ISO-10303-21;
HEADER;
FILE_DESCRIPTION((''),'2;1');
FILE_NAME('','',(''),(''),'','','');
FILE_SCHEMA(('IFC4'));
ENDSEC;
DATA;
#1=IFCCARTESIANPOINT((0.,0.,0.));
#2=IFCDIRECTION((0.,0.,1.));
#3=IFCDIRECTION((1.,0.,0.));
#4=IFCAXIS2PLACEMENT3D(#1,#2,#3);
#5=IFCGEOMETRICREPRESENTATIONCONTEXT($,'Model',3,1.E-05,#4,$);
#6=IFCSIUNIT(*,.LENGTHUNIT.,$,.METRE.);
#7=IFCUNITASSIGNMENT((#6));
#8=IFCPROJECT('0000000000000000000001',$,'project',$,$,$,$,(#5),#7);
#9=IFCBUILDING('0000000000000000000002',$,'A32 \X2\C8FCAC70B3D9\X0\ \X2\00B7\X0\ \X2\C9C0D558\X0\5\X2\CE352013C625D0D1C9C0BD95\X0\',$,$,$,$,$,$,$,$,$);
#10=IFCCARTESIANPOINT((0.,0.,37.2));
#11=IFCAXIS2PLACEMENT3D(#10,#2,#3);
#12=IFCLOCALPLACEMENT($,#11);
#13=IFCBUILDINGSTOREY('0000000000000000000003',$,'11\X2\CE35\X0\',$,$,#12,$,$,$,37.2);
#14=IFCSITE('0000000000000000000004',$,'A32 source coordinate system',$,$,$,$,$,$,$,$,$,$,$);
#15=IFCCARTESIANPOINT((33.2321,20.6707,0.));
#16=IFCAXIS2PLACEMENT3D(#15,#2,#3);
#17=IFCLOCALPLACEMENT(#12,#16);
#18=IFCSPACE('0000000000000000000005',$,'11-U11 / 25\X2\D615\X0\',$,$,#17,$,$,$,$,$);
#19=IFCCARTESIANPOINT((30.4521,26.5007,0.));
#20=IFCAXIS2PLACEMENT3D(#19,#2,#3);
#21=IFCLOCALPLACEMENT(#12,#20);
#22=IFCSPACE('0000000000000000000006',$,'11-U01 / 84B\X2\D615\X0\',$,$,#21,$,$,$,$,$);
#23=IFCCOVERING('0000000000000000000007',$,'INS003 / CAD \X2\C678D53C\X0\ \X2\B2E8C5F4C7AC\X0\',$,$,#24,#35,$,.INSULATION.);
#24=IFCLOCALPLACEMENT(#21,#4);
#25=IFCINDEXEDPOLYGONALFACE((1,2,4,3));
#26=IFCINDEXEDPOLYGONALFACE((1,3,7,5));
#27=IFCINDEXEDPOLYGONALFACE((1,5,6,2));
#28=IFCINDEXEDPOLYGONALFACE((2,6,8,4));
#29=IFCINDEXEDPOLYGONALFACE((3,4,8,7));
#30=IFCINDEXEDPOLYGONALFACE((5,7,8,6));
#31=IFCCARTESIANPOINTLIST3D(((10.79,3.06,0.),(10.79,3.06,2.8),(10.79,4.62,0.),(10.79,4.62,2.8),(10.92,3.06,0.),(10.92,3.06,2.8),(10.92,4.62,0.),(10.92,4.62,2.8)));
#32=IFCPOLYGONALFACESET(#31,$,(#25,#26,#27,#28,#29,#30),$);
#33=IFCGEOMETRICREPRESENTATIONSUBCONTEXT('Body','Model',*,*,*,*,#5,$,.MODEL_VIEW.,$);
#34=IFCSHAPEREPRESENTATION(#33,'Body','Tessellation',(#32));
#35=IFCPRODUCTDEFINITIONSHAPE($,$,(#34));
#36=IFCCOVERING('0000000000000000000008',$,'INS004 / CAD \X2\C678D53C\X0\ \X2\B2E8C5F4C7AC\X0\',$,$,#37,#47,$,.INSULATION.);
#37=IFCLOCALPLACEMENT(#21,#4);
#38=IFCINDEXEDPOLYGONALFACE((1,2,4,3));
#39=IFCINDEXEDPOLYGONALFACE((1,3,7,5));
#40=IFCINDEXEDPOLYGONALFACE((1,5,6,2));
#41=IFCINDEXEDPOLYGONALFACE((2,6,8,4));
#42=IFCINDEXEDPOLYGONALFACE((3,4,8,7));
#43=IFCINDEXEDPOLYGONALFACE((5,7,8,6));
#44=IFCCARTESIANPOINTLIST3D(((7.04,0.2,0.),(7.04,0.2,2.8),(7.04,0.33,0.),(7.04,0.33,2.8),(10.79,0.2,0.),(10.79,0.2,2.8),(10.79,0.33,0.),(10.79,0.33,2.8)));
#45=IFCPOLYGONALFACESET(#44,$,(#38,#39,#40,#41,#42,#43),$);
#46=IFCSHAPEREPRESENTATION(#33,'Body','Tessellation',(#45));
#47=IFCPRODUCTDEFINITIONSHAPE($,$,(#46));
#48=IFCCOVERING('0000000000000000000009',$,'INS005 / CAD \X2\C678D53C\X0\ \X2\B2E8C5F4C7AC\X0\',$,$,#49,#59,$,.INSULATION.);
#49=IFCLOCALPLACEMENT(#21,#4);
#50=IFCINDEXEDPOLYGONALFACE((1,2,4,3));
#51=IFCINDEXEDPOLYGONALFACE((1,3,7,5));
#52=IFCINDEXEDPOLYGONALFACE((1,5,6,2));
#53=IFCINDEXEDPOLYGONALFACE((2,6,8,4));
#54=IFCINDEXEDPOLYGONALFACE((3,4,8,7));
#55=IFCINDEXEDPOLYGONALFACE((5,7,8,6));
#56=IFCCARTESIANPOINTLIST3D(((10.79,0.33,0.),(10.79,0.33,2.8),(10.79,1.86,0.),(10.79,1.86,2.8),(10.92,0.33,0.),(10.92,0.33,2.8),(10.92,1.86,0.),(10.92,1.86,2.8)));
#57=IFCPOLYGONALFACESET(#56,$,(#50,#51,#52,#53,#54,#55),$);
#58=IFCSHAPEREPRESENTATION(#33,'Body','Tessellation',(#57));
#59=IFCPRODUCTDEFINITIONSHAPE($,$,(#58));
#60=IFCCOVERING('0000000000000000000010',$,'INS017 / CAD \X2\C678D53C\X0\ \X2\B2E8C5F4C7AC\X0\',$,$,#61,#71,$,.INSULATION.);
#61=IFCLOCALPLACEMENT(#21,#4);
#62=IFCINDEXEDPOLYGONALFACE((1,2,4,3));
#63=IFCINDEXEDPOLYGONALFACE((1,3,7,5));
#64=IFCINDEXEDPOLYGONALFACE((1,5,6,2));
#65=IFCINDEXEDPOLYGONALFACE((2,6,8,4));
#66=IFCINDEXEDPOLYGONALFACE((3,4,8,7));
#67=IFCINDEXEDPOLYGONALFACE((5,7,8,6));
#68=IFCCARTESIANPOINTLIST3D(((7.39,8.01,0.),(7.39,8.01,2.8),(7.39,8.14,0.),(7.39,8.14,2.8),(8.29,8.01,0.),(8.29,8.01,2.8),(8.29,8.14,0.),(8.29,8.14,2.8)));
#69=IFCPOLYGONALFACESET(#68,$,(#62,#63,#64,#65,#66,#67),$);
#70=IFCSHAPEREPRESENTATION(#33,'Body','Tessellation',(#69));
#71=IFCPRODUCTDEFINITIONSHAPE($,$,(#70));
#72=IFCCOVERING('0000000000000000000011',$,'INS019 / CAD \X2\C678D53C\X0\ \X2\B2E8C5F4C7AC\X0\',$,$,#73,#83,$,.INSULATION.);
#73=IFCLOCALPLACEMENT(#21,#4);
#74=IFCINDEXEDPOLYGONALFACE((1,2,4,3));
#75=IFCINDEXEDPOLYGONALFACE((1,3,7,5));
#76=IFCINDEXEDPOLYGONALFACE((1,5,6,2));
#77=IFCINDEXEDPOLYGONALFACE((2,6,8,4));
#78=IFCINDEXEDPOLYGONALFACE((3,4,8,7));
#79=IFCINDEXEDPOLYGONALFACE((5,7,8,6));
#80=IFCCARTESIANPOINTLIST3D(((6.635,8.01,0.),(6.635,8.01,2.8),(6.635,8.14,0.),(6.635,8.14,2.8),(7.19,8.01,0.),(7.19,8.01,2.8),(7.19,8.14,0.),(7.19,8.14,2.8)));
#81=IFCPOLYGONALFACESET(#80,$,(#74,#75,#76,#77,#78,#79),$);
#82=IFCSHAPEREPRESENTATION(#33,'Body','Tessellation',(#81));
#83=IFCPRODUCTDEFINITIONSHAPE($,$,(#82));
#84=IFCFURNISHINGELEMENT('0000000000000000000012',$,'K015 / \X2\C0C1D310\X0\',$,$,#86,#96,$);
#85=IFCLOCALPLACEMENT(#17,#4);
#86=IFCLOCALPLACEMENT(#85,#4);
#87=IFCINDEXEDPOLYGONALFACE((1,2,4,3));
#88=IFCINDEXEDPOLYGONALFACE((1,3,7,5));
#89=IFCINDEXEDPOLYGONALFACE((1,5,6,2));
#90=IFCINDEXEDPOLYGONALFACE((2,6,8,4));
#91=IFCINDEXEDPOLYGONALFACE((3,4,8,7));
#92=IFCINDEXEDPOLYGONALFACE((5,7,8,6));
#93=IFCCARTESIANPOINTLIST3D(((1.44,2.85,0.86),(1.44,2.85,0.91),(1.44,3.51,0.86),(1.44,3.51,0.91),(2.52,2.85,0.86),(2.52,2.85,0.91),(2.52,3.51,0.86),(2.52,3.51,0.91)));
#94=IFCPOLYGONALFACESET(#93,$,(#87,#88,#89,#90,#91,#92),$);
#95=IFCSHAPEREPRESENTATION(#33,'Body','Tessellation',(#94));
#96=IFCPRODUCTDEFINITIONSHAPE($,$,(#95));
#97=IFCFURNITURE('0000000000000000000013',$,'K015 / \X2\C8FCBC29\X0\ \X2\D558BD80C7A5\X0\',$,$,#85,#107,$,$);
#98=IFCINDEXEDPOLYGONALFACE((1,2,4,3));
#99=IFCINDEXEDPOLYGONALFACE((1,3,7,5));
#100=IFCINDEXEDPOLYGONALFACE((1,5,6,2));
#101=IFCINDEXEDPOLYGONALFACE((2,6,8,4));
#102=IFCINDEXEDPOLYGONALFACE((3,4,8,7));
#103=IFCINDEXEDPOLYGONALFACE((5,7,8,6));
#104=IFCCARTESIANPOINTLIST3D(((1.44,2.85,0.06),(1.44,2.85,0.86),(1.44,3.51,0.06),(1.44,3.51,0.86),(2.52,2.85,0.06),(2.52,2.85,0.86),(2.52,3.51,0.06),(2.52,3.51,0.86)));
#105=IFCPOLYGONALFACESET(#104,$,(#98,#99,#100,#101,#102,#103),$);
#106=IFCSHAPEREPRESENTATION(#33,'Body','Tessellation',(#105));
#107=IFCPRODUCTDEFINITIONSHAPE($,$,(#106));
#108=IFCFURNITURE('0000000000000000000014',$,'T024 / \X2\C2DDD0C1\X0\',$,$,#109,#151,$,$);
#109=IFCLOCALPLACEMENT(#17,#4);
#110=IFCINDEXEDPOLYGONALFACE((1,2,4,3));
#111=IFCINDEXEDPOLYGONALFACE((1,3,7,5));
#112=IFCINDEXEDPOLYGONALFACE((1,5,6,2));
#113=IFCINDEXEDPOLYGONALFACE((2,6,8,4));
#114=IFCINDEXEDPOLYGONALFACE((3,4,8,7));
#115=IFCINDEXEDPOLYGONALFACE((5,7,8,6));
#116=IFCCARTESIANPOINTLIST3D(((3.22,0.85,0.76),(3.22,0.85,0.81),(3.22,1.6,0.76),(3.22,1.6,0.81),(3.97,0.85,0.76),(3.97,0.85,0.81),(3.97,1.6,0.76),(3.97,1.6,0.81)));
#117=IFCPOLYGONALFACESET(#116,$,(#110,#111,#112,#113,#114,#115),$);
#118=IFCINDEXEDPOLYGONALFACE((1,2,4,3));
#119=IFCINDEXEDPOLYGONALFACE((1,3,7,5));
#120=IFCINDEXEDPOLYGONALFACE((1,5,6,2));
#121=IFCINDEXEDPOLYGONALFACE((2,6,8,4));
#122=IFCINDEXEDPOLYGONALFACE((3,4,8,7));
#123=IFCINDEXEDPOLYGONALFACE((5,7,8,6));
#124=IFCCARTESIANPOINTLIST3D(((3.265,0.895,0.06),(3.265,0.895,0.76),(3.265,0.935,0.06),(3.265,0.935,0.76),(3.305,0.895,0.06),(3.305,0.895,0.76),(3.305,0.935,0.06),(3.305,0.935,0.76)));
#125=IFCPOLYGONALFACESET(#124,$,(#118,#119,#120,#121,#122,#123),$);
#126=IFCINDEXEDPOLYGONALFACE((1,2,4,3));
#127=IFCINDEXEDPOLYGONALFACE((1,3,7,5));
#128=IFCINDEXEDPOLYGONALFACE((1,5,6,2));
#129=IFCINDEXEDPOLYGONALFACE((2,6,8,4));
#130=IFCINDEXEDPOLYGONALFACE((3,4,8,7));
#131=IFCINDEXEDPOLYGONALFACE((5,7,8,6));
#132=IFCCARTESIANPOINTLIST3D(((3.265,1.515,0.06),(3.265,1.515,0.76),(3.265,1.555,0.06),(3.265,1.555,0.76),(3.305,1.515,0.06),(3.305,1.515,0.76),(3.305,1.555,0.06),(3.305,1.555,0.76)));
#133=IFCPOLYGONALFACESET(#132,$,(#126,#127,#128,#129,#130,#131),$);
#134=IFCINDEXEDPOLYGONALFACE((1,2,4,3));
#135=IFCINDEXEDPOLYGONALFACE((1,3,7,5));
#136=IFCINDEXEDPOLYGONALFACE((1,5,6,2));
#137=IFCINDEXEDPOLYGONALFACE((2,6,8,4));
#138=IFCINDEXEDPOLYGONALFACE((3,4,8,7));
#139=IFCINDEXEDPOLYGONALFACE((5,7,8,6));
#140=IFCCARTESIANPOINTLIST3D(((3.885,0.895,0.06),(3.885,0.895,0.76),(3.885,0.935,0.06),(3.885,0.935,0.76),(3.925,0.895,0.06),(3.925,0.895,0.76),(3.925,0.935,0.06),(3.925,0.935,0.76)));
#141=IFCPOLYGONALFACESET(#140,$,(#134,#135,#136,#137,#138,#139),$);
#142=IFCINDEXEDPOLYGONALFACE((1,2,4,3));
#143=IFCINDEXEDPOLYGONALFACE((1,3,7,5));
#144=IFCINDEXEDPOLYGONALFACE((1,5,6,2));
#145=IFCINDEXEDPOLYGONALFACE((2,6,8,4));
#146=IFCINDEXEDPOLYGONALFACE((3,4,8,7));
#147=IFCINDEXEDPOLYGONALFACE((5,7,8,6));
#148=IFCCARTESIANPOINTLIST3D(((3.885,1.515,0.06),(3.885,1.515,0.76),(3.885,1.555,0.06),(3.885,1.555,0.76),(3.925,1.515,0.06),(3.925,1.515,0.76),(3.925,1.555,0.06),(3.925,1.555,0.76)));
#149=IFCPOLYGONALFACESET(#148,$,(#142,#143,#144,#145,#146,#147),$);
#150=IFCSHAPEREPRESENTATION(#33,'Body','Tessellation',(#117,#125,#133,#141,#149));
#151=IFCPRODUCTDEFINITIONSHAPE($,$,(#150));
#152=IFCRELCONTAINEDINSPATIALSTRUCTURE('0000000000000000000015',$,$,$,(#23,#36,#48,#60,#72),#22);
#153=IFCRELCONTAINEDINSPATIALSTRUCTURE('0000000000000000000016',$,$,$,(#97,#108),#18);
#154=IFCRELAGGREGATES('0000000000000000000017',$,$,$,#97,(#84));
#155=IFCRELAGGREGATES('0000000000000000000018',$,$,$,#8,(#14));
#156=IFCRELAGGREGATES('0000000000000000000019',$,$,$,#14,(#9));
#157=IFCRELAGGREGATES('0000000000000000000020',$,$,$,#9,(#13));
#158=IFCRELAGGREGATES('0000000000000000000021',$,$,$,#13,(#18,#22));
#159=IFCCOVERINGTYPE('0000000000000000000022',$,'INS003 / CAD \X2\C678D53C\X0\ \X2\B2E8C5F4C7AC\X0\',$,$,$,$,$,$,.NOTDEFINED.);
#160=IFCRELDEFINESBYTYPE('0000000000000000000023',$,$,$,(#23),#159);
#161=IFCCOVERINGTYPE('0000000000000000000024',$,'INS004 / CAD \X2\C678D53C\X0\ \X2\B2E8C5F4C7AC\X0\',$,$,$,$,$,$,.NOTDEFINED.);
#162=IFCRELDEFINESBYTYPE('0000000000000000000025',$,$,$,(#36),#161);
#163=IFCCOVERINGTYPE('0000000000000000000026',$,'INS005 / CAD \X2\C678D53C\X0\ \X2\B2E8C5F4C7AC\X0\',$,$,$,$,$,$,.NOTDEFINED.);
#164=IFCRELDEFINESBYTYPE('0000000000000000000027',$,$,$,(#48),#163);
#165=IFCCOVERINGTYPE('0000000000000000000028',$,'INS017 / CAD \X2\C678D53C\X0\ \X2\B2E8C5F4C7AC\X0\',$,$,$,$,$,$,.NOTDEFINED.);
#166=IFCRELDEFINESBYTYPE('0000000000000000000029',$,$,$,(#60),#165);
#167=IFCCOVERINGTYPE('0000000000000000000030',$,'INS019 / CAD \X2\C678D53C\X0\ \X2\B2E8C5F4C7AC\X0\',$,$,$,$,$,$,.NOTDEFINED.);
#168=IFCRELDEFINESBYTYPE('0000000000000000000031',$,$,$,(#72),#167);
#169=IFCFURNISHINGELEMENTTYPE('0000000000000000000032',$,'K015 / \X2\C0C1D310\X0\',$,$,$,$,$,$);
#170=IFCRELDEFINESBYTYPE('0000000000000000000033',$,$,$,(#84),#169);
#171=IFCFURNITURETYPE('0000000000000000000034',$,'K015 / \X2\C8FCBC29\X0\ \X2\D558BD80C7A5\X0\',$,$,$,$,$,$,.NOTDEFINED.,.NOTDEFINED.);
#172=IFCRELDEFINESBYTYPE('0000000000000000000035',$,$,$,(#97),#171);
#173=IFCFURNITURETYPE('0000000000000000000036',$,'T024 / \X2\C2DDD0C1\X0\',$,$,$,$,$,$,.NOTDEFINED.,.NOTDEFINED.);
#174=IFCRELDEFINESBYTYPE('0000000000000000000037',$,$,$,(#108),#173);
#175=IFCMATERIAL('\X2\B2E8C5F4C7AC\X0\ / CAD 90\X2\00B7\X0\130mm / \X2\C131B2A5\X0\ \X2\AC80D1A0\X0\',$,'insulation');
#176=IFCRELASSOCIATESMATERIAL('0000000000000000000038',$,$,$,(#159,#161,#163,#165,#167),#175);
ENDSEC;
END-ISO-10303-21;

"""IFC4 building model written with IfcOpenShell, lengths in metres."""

from ifc_helpers import new_model, si_unit, frame, origin, origin_with_axes, place, context, subcontext, project, spatial, polyline, outline, extrude, source, transform, mapped, material, type_object, type_shapes, element, aggregate, save


model = new_model("IFC4")

# Units and contexts
model_context = context("Model", 3, precision=1e-05, world=origin_with_axes())
body_context = subcontext(model_context, "Body", "Model", "MODEL_VIEW")
ifc_project = project(units=[si_unit("LENGTHUNIT", "METRE")], contexts=[model_context])

# Site, building, storey, space
site = spatial("IfcSite", under=ifc_project, Name="A32 source coordinate system")
building = spatial("IfcBuilding", under=site, Name="A32 주거동 · 지하5층–옥탑지붕")
storey_placement = place(None, frame((0.0, 0.0, 37.2), z_axis=(0.0, 0.0, 1.0), x_axis=(1.0, 0.0, 0.0)))
storey = spatial("IfcBuildingStorey", under=building, at=storey_placement, Name="11층", Elevation=37.2)
space_1_placement = place(storey_placement, frame((33.2321, 20.6707, 0.0), z_axis=(0.0, 0.0, 1.0), x_axis=(1.0, 0.0, 0.0)))
space_1 = spatial("IfcSpace", under=storey, at=space_1_placement, Name="11-U11 / 25형")

# Shared definitions
space_2_placement = place(storey_placement, frame((30.4521, 26.5007, 0.0), z_axis=(0.0, 0.0, 1.0), x_axis=(1.0, 0.0, 0.0)))
space_2 = spatial("IfcSpace", under=storey, at=space_2_placement, Name="11-U01 / 84B형")

# Coverings
ifc_material = material(Name="단열재 / CAD 90·130mm / 성능 검토", Category="insulation")
covering_type_1 = type_object("IfcCoveringType", Name="INS003 / CAD 외피 단열재", PredefinedType="NOTDEFINED", material=ifc_material)
shared_shape_1 = source(origin(), body_context, "Body", "SweptSolid", [
    extrude(outline(polyline([(10.79, 3.06), (10.79, 4.62), (10.92, 4.62), (10.92, 3.06), (10.79, 3.06)])), origin(), (0.0, 0.0, 1.0), 2.8),
])
type_shapes(covering_type_1, [shared_shape_1])
covering_1_placement = place(space_2_placement, origin_with_axes())
element("IfcCovering", 1, at=covering_1_placement, inside=space_2, type_object=covering_type_1, Name="INS003 / CAD 외피 단열재", PredefinedType="INSULATION", context=body_context, shape_type="MappedRepresentation", body=[
    mapped(shared_shape_1, transform((0.0, 0.0, 0.0), scale=1.0)),
])
covering_type_2 = type_object("IfcCoveringType", Name="INS004 / CAD 외피 단열재", PredefinedType="NOTDEFINED", material=ifc_material)
shared_shape_2 = source(origin(), body_context, "Body", "SweptSolid", [
    extrude(outline(polyline([(7.04, 0.33), (10.79, 0.33), (10.79, 0.2), (7.04, 0.2), (7.04, 0.33)])), origin(), (0.0, 0.0, 1.0), 2.8),
])
type_shapes(covering_type_2, [shared_shape_2])
covering_2_placement = place(space_2_placement, origin_with_axes())
element("IfcCovering", 2, at=covering_2_placement, inside=space_2, type_object=covering_type_2, Name="INS004 / CAD 외피 단열재", PredefinedType="INSULATION", context=body_context, shape_type="MappedRepresentation", body=[
    mapped(shared_shape_2, transform((0.0, 0.0, 0.0), scale=1.0)),
])
covering_type_3 = type_object("IfcCoveringType", Name="INS005 / CAD 외피 단열재", PredefinedType="NOTDEFINED", material=ifc_material)
shared_shape_3 = source(origin(), body_context, "Body", "SweptSolid", [
    extrude(outline(polyline([(10.79, 0.33), (10.79, 1.86), (10.92, 1.86), (10.92, 0.33), (10.79, 0.33)])), origin(), (0.0, 0.0, 1.0), 2.8),
])
type_shapes(covering_type_3, [shared_shape_3])
covering_3_placement = place(space_2_placement, origin_with_axes())
element("IfcCovering", 3, at=covering_3_placement, inside=space_2, type_object=covering_type_3, Name="INS005 / CAD 외피 단열재", PredefinedType="INSULATION", context=body_context, shape_type="MappedRepresentation", body=[
    mapped(shared_shape_3, transform((0.0, 0.0, 0.0), scale=1.0)),
])
covering_type_4 = type_object("IfcCoveringType", Name="INS017 / CAD 외피 단열재", PredefinedType="NOTDEFINED", material=ifc_material)
shared_shape_4 = source(origin(), body_context, "Body", "SweptSolid", [
    extrude(outline(polyline([(8.29, 8.01), (7.39, 8.01), (7.39, 8.14), (8.29, 8.14), (8.29, 8.01)])), origin(), (0.0, 0.0, 1.0), 2.8),
])
type_shapes(covering_type_4, [shared_shape_4])
covering_4_placement = place(space_2_placement, origin_with_axes())
element("IfcCovering", 4, at=covering_4_placement, inside=space_2, type_object=covering_type_4, Name="INS017 / CAD 외피 단열재", PredefinedType="INSULATION", context=body_context, shape_type="MappedRepresentation", body=[
    mapped(shared_shape_4, transform((0.0, 0.0, 0.0), scale=1.0)),
])
covering_type_5 = type_object("IfcCoveringType", Name="INS019 / CAD 외피 단열재", PredefinedType="NOTDEFINED", material=ifc_material)
shared_shape_5 = source(origin(), body_context, "Body", "SweptSolid", [
    extrude(outline(polyline([(6.635, 8.01), (6.635, 8.14), (7.19, 8.14), (7.19, 8.01), (6.635, 8.01)])), origin(), (0.0, 0.0, 1.0), 2.8),
])
type_shapes(covering_type_5, [shared_shape_5])
covering_5_placement = place(space_2_placement, origin_with_axes())
element("IfcCovering", 5, at=covering_5_placement, inside=space_2, type_object=covering_type_5, Name="INS019 / CAD 외피 단열재", PredefinedType="INSULATION", context=body_context, shape_type="MappedRepresentation", body=[
    mapped(shared_shape_5, transform((0.0, 0.0, 0.0), scale=1.0)),
])

# Furnishing element
furnishing_element_type_1 = type_object("IfcFurnishingElementType", Name="K015 / 상판")
shared_shape_6 = source(origin(), body_context, "Body", "SweptSolid", [
    extrude(outline(polyline([(2.52, 2.85), (1.44, 2.85), (1.44, 3.51), (2.52, 3.51), (2.52, 2.85)])), frame((0.0, 0.0, 0.86)), (0.0, 0.0, 1.0), 0.05),
])
type_shapes(furnishing_element_type_1, [shared_shape_6])
furniture_1_placement = place(space_1_placement, origin_with_axes())
furnishing_1_placement = place(furniture_1_placement, origin_with_axes())
furnishing_1 = element("IfcFurnishingElement", 6, at=furnishing_1_placement, type_object=furnishing_element_type_1, Name="K015 / 상판", context=body_context, shape_type="MappedRepresentation", body=[
    mapped(shared_shape_6, transform((0.0, 0.0, 0.0), scale=1.0)),
])

# Furniture
furniture_type_1 = type_object("IfcFurnitureType", Name="K015 / 주방 하부장", AssemblyPlace="NOTDEFINED", PredefinedType="NOTDEFINED")
shared_shape_7 = source(origin(), body_context, "Body", "SweptSolid", [
    extrude(outline(polyline([(2.52, 3.51), (2.52, 2.85), (1.44, 2.85), (1.44, 3.51), (2.52, 3.51)])), frame((0.0, 0.0, 0.06)), (0.0, 0.0, 1.0), 0.8),
])
type_shapes(furniture_type_1, [shared_shape_7])
furniture_1 = element("IfcFurniture", 7, at=furniture_1_placement, inside=space_1, type_object=furniture_type_1, Name="K015 / 주방 하부장", context=body_context, shape_type="MappedRepresentation", body=[
    mapped(shared_shape_7, transform((0.0, 0.0, 0.0), scale=1.0)),
])
aggregate(furniture_1, [furnishing_1])
furniture_type_2 = type_object("IfcFurnitureType", Name="T024 / 식탁", AssemblyPlace="NOTDEFINED", PredefinedType="NOTDEFINED")
shared_shape_8 = source(origin(), body_context, "Body", "SweptSolid", [
    extrude(outline(polyline([(3.22, 0.85), (3.22, 1.6), (3.97, 1.6), (3.97, 0.85), (3.22, 0.85)])), frame((0.0, 0.0, 0.76)), (0.0, 0.0, 1.0), 0.05),
    extrude(outline(polyline([(3.265, 0.895), (3.265, 0.935), (3.305, 0.935), (3.305, 0.895), (3.265, 0.895)])), frame((0.0, 0.0, 0.06)), (0.0, 0.0, 1.0), 0.7),
    extrude(outline(polyline([(3.265, 1.515), (3.265, 1.555), (3.305, 1.555), (3.305, 1.515), (3.265, 1.515)])), frame((0.0, 0.0, 0.06)), (0.0, 0.0, 1.0), 0.7),
    extrude(outline(polyline([(3.885, 0.895), (3.885, 0.935), (3.925, 0.935), (3.925, 0.895), (3.885, 0.895)])), frame((0.0, 0.0, 0.06)), (0.0, 0.0, 1.0), 0.7),
    extrude(outline(polyline([(3.885, 1.515), (3.885, 1.555), (3.925, 1.555), (3.925, 1.515), (3.885, 1.515)])), frame((0.0, 0.0, 0.06)), (0.0, 0.0, 1.0), 0.7),
])
type_shapes(furniture_type_2, [shared_shape_8])
furniture_2_placement = place(space_1_placement, origin_with_axes())
element("IfcFurniture", 8, at=furniture_2_placement, inside=space_1, type_object=furniture_type_2, Name="T024 / 식탁", context=body_context, shape_type="MappedRepresentation", body=[
    mapped(shared_shape_8, transform((0.0, 0.0, 0.0), scale=1.0)),
])

save(model, "model.ifc")
